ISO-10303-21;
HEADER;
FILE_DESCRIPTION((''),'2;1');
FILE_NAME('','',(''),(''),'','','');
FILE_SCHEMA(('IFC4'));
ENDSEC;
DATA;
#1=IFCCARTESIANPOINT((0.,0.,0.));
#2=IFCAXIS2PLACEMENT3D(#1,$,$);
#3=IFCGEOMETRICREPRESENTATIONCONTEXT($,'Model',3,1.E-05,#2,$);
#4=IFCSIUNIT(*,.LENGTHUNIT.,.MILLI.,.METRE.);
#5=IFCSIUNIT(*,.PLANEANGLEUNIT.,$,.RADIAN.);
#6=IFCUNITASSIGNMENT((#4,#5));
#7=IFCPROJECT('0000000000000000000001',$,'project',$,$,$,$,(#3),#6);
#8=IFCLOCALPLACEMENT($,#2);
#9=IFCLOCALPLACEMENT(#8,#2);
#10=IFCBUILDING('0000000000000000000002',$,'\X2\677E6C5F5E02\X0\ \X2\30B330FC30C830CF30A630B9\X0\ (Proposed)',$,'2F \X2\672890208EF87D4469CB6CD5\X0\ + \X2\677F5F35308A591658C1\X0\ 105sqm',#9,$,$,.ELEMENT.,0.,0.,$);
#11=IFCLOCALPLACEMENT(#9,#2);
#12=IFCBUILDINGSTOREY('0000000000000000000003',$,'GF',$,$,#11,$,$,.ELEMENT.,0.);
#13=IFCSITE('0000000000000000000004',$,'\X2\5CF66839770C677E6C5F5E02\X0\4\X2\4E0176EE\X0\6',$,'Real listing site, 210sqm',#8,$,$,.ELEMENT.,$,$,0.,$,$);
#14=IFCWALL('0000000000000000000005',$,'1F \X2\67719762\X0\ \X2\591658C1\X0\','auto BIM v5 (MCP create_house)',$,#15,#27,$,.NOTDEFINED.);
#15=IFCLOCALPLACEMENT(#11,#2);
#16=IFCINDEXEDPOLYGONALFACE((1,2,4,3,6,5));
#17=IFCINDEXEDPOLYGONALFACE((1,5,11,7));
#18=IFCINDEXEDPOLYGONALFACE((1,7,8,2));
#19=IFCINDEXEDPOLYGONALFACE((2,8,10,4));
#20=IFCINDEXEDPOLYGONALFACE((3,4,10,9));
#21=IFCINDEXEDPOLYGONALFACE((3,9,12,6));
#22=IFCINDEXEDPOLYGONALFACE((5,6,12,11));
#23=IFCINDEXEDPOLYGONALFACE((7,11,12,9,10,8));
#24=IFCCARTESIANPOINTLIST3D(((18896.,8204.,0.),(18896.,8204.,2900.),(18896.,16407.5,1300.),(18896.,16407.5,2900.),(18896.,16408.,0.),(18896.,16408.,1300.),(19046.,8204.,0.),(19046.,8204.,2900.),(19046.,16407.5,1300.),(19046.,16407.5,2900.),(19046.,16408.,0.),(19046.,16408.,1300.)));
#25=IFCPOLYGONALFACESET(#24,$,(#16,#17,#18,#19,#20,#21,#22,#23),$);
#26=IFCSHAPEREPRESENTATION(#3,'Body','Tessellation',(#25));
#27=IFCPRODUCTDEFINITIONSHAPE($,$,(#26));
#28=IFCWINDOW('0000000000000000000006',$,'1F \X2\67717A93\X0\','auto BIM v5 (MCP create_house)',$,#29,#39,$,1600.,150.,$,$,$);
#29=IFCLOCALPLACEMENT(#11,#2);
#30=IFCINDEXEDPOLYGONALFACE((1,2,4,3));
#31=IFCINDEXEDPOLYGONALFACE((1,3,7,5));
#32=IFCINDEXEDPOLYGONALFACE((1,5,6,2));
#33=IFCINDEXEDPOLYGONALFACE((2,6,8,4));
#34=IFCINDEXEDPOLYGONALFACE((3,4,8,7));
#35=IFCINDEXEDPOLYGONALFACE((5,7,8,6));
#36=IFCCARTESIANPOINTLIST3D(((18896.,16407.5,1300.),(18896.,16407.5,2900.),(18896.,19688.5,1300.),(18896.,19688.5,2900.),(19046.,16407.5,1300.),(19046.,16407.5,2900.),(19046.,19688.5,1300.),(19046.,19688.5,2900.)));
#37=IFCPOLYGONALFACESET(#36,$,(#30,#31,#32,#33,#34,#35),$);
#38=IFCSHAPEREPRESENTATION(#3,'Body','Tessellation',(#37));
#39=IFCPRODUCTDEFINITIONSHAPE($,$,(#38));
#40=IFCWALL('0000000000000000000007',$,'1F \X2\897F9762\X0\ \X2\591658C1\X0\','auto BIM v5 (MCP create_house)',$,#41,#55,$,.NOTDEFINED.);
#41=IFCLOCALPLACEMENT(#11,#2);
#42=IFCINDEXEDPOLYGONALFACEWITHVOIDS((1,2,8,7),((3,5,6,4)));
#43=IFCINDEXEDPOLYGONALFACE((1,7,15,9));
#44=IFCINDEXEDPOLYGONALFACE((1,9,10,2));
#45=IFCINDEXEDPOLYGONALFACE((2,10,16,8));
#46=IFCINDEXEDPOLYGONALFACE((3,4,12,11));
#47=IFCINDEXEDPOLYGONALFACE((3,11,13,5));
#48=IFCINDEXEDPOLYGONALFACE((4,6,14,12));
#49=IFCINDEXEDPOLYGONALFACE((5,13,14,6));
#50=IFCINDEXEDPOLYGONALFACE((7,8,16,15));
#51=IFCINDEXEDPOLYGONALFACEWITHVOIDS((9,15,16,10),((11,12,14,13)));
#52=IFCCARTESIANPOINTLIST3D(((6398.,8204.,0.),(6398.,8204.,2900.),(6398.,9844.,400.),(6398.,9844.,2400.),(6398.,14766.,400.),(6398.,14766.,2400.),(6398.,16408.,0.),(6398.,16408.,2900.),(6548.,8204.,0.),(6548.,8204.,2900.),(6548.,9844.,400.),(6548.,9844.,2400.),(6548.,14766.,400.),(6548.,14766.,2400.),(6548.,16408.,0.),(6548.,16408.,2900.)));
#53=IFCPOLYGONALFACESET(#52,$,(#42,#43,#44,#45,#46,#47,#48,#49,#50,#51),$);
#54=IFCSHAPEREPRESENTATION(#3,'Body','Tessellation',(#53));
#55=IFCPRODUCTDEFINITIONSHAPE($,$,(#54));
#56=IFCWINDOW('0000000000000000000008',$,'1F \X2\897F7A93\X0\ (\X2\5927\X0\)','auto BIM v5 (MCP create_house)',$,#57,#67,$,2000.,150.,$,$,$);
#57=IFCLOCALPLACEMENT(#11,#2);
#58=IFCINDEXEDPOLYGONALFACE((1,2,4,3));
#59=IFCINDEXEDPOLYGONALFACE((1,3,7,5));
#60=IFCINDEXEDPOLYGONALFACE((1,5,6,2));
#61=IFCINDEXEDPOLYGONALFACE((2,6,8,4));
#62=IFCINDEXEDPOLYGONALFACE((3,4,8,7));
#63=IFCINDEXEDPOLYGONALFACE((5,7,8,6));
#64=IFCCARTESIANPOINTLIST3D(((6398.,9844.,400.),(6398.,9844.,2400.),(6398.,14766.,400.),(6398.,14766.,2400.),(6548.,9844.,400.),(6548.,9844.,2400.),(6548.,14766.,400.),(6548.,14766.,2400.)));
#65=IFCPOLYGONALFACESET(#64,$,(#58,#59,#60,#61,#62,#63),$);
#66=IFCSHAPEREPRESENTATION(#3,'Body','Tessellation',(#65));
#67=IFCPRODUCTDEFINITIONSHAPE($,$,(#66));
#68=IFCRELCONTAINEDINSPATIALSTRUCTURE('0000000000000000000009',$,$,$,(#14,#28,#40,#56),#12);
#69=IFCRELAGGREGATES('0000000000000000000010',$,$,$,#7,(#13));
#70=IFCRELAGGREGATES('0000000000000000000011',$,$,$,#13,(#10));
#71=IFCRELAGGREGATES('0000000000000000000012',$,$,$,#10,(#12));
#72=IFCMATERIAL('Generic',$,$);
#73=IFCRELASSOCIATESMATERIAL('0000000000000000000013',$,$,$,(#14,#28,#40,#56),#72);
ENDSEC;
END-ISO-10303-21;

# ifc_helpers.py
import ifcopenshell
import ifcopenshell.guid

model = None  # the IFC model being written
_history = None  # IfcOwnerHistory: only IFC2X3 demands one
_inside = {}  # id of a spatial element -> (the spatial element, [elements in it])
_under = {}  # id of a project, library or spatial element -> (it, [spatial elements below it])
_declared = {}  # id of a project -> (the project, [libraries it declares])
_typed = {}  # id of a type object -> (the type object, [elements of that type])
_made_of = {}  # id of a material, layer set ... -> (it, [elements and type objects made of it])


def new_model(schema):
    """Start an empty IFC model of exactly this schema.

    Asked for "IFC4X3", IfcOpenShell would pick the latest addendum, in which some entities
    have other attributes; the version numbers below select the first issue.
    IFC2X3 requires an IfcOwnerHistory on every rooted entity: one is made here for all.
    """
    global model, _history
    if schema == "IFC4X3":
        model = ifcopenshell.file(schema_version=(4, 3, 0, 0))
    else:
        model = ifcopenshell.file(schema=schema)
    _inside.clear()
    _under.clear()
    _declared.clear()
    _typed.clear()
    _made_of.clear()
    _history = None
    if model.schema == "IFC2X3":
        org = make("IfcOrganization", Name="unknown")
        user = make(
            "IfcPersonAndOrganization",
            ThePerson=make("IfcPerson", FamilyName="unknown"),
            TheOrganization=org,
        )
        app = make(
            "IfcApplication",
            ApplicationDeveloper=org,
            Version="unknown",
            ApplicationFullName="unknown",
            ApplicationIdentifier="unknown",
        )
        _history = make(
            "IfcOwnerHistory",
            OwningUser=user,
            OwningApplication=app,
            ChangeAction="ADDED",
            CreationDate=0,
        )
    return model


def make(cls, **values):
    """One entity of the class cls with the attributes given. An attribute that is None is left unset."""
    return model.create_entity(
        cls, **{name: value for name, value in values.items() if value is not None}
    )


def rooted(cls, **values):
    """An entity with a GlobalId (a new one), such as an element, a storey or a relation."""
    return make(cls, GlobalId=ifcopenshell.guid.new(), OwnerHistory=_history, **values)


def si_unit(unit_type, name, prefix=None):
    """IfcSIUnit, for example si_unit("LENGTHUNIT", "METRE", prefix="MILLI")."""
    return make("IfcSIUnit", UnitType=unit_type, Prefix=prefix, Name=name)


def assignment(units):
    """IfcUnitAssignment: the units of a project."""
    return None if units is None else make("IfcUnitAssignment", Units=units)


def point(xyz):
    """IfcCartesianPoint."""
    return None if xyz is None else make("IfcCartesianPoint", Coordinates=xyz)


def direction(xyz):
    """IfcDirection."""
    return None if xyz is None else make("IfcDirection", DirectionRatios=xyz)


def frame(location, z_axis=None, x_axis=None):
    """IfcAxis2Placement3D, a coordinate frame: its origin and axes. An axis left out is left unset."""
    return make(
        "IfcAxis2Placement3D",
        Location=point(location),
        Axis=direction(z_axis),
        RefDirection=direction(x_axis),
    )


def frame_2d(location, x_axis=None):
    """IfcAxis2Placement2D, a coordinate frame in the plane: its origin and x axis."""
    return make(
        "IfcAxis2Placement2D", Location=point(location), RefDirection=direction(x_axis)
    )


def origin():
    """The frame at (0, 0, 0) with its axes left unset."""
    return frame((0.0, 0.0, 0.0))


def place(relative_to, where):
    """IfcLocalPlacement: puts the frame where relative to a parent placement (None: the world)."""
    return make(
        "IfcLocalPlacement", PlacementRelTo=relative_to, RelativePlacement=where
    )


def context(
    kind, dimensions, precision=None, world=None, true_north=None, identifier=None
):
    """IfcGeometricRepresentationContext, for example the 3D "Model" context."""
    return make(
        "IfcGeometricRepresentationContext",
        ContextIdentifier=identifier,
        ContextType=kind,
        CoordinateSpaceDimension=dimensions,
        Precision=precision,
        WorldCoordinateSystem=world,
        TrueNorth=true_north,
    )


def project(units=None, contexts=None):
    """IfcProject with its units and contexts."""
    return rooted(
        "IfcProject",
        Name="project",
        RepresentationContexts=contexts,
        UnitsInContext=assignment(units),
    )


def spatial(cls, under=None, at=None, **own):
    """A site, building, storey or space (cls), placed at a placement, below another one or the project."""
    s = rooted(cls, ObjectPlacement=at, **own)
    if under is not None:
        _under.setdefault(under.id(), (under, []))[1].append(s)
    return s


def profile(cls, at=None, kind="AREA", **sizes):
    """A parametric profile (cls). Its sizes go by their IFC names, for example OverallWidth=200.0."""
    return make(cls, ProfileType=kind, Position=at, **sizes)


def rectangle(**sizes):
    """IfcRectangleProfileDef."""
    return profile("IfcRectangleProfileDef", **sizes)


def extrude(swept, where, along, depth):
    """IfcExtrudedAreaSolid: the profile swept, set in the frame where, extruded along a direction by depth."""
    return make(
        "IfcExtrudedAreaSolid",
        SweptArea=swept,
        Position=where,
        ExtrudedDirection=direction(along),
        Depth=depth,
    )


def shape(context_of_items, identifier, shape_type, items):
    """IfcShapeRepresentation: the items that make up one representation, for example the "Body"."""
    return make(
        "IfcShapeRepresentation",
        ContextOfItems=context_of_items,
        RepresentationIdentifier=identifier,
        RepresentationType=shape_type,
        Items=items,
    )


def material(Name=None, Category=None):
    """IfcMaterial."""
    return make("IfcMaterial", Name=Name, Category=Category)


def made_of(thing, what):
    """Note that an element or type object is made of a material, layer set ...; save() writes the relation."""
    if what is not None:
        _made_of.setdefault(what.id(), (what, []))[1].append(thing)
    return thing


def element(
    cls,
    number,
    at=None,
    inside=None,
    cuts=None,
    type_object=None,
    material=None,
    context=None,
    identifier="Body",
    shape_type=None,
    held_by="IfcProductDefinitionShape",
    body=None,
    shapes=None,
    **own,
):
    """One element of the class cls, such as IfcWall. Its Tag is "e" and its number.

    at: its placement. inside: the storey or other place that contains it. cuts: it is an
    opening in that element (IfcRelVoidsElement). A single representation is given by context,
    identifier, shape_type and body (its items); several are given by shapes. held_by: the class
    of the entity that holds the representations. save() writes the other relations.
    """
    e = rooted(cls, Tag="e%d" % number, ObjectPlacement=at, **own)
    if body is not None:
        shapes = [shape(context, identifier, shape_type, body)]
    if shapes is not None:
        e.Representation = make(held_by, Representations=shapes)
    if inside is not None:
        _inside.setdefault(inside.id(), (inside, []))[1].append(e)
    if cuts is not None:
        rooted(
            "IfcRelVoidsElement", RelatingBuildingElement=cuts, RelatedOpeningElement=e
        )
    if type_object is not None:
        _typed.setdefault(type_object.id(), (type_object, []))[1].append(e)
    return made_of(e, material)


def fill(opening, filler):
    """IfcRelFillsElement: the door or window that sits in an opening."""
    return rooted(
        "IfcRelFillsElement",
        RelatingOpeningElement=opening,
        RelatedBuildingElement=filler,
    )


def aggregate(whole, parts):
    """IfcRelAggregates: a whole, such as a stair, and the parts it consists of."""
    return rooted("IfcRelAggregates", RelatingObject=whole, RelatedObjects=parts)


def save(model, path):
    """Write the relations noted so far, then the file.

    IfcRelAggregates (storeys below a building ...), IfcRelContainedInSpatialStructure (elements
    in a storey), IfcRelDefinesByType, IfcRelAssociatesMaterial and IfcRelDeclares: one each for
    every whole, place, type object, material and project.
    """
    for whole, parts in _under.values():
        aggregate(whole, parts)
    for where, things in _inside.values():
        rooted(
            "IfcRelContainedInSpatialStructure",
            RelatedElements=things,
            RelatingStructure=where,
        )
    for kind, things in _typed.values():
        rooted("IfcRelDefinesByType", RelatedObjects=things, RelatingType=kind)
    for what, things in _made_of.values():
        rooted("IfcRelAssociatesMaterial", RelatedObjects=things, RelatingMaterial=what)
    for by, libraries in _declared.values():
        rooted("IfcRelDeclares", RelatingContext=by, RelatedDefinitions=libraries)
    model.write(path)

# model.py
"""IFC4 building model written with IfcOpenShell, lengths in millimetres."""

from ifc_helpers import new_model, si_unit, frame, frame_2d, origin, place, context, project, spatial, rectangle, extrude, material, element, fill, save


model = new_model("IFC4")

# Units and contexts
model_context = context("Model", 3, precision=1e-05, world=origin())
ifc_project = project(units=[si_unit("LENGTHUNIT", "METRE", prefix="MILLI"), si_unit("PLANEANGLEUNIT", "RADIAN")], contexts=[model_context])

# Site, building, storey
site_placement = place(None, origin())
site = spatial("IfcSite", under=ifc_project, at=site_placement, Name="島根県松江市4丁目6", ObjectType="Real listing site, 210sqm", CompositionType="ELEMENT", RefElevation=0.0)
building_placement = place(site_placement, origin())
building = spatial("IfcBuilding", under=site, at=building_placement, Name="松江市 コートハウス (Proposed)", ObjectType="2F 木造軸組構法 + 板張り外壁 105sqm", CompositionType="ELEMENT", ElevationOfRefHeight=0.0, ElevationOfTerrain=0.0)
storey_placement = place(building_placement, origin())
storey = spatial("IfcBuildingStorey", under=building, at=storey_placement, Name="GF", CompositionType="ELEMENT", Elevation=0.0)

# Shared definitions
ifc_material = material(Name="Generic")

# Walls, openings, windows
wall_1_placement = place(storey_placement, frame((9448.0, 4102.0, 0.0)))
wall_1 = element("IfcWall", 1, at=wall_1_placement, inside=storey, material=ifc_material, Name="1F 東面 外壁", Description="auto BIM v5 (MCP create_house)", PredefinedType="NOTDEFINED", context=model_context, shape_type="SweptSolid", body=[
    extrude(rectangle(XDim=150.0, YDim=8204.0, at=frame_2d((75.0, 4102.0))), frame((9448.0, 4102.0, 0.0)), (0.0, 0.0, 1.0), 2900.0),
])
opening_1_placement = place(storey_placement, frame((9448.0, 8204.0, 650.0)))
opening_1 = element("IfcOpeningElement", 2, at=opening_1_placement, cuts=wall_1, PredefinedType="NOTDEFINED", context=model_context, shape_type="SweptSolid", body=[
    extrude(rectangle(XDim=150.0, YDim=3281.0, at=frame_2d((75.0, 1640.0))), frame((9448.0, 8204.0, 650.0)), (0.0, 0.0, 1.0), 1600.0),
])
window_1_placement = place(storey_placement, frame((9448.0, 8204.0, 650.0)))
window_1 = element("IfcWindow", 3, at=window_1_placement, inside=storey, material=ifc_material, Name="1F 東窓", Description="auto BIM v5 (MCP create_house)", OverallHeight=1600.0, OverallWidth=150.0, context=model_context, shape_type="SweptSolid", body=[
    extrude(rectangle(XDim=150.0, YDim=3281.0, at=frame_2d((75.0, 1640.0))), frame((9448.0, 8204.0, 650.0)), (0.0, 0.0, 1.0), 1600.0),
])
fill(opening_1, window_1)
wall_2_placement = place(storey_placement, frame((3199.0, 4102.0, 0.0)))
wall_2 = element("IfcWall", 4, at=wall_2_placement, inside=storey, material=ifc_material, Name="1F 西面 外壁", Description="auto BIM v5 (MCP create_house)", PredefinedType="NOTDEFINED", context=model_context, shape_type="SweptSolid", body=[
    extrude(rectangle(XDim=150.0, YDim=8204.0, at=frame_2d((75.0, 4102.0))), frame((3199.0, 4102.0, 0.0)), (0.0, 0.0, 1.0), 2900.0),
])
opening_2_placement = place(storey_placement, frame((3199.0, 4922.0, 200.0)))
opening_2 = element("IfcOpeningElement", 5, at=opening_2_placement, cuts=wall_2, PredefinedType="NOTDEFINED", context=model_context, shape_type="SweptSolid", body=[
    extrude(rectangle(XDim=150.0, YDim=4922.0, at=frame_2d((75.0, 2461.0))), frame((3199.0, 4922.0, 200.0)), (0.0, 0.0, 1.0), 2000.0),
])
window_2_placement = place(storey_placement, frame((3199.0, 4922.0, 200.0)))
window_2 = element("IfcWindow", 6, at=window_2_placement, inside=storey, material=ifc_material, Name="1F 西窓 (大)", Description="auto BIM v5 (MCP create_house)", OverallHeight=2000.0, OverallWidth=150.0, context=model_context, shape_type="SweptSolid", body=[
    extrude(rectangle(XDim=150.0, YDim=4922.0, at=frame_2d((75.0, 2461.0))), frame((3199.0, 4922.0, 200.0)), (0.0, 0.0, 1.0), 2000.0),
])
fill(opening_2, window_2)

save(model, "model.ifc")
